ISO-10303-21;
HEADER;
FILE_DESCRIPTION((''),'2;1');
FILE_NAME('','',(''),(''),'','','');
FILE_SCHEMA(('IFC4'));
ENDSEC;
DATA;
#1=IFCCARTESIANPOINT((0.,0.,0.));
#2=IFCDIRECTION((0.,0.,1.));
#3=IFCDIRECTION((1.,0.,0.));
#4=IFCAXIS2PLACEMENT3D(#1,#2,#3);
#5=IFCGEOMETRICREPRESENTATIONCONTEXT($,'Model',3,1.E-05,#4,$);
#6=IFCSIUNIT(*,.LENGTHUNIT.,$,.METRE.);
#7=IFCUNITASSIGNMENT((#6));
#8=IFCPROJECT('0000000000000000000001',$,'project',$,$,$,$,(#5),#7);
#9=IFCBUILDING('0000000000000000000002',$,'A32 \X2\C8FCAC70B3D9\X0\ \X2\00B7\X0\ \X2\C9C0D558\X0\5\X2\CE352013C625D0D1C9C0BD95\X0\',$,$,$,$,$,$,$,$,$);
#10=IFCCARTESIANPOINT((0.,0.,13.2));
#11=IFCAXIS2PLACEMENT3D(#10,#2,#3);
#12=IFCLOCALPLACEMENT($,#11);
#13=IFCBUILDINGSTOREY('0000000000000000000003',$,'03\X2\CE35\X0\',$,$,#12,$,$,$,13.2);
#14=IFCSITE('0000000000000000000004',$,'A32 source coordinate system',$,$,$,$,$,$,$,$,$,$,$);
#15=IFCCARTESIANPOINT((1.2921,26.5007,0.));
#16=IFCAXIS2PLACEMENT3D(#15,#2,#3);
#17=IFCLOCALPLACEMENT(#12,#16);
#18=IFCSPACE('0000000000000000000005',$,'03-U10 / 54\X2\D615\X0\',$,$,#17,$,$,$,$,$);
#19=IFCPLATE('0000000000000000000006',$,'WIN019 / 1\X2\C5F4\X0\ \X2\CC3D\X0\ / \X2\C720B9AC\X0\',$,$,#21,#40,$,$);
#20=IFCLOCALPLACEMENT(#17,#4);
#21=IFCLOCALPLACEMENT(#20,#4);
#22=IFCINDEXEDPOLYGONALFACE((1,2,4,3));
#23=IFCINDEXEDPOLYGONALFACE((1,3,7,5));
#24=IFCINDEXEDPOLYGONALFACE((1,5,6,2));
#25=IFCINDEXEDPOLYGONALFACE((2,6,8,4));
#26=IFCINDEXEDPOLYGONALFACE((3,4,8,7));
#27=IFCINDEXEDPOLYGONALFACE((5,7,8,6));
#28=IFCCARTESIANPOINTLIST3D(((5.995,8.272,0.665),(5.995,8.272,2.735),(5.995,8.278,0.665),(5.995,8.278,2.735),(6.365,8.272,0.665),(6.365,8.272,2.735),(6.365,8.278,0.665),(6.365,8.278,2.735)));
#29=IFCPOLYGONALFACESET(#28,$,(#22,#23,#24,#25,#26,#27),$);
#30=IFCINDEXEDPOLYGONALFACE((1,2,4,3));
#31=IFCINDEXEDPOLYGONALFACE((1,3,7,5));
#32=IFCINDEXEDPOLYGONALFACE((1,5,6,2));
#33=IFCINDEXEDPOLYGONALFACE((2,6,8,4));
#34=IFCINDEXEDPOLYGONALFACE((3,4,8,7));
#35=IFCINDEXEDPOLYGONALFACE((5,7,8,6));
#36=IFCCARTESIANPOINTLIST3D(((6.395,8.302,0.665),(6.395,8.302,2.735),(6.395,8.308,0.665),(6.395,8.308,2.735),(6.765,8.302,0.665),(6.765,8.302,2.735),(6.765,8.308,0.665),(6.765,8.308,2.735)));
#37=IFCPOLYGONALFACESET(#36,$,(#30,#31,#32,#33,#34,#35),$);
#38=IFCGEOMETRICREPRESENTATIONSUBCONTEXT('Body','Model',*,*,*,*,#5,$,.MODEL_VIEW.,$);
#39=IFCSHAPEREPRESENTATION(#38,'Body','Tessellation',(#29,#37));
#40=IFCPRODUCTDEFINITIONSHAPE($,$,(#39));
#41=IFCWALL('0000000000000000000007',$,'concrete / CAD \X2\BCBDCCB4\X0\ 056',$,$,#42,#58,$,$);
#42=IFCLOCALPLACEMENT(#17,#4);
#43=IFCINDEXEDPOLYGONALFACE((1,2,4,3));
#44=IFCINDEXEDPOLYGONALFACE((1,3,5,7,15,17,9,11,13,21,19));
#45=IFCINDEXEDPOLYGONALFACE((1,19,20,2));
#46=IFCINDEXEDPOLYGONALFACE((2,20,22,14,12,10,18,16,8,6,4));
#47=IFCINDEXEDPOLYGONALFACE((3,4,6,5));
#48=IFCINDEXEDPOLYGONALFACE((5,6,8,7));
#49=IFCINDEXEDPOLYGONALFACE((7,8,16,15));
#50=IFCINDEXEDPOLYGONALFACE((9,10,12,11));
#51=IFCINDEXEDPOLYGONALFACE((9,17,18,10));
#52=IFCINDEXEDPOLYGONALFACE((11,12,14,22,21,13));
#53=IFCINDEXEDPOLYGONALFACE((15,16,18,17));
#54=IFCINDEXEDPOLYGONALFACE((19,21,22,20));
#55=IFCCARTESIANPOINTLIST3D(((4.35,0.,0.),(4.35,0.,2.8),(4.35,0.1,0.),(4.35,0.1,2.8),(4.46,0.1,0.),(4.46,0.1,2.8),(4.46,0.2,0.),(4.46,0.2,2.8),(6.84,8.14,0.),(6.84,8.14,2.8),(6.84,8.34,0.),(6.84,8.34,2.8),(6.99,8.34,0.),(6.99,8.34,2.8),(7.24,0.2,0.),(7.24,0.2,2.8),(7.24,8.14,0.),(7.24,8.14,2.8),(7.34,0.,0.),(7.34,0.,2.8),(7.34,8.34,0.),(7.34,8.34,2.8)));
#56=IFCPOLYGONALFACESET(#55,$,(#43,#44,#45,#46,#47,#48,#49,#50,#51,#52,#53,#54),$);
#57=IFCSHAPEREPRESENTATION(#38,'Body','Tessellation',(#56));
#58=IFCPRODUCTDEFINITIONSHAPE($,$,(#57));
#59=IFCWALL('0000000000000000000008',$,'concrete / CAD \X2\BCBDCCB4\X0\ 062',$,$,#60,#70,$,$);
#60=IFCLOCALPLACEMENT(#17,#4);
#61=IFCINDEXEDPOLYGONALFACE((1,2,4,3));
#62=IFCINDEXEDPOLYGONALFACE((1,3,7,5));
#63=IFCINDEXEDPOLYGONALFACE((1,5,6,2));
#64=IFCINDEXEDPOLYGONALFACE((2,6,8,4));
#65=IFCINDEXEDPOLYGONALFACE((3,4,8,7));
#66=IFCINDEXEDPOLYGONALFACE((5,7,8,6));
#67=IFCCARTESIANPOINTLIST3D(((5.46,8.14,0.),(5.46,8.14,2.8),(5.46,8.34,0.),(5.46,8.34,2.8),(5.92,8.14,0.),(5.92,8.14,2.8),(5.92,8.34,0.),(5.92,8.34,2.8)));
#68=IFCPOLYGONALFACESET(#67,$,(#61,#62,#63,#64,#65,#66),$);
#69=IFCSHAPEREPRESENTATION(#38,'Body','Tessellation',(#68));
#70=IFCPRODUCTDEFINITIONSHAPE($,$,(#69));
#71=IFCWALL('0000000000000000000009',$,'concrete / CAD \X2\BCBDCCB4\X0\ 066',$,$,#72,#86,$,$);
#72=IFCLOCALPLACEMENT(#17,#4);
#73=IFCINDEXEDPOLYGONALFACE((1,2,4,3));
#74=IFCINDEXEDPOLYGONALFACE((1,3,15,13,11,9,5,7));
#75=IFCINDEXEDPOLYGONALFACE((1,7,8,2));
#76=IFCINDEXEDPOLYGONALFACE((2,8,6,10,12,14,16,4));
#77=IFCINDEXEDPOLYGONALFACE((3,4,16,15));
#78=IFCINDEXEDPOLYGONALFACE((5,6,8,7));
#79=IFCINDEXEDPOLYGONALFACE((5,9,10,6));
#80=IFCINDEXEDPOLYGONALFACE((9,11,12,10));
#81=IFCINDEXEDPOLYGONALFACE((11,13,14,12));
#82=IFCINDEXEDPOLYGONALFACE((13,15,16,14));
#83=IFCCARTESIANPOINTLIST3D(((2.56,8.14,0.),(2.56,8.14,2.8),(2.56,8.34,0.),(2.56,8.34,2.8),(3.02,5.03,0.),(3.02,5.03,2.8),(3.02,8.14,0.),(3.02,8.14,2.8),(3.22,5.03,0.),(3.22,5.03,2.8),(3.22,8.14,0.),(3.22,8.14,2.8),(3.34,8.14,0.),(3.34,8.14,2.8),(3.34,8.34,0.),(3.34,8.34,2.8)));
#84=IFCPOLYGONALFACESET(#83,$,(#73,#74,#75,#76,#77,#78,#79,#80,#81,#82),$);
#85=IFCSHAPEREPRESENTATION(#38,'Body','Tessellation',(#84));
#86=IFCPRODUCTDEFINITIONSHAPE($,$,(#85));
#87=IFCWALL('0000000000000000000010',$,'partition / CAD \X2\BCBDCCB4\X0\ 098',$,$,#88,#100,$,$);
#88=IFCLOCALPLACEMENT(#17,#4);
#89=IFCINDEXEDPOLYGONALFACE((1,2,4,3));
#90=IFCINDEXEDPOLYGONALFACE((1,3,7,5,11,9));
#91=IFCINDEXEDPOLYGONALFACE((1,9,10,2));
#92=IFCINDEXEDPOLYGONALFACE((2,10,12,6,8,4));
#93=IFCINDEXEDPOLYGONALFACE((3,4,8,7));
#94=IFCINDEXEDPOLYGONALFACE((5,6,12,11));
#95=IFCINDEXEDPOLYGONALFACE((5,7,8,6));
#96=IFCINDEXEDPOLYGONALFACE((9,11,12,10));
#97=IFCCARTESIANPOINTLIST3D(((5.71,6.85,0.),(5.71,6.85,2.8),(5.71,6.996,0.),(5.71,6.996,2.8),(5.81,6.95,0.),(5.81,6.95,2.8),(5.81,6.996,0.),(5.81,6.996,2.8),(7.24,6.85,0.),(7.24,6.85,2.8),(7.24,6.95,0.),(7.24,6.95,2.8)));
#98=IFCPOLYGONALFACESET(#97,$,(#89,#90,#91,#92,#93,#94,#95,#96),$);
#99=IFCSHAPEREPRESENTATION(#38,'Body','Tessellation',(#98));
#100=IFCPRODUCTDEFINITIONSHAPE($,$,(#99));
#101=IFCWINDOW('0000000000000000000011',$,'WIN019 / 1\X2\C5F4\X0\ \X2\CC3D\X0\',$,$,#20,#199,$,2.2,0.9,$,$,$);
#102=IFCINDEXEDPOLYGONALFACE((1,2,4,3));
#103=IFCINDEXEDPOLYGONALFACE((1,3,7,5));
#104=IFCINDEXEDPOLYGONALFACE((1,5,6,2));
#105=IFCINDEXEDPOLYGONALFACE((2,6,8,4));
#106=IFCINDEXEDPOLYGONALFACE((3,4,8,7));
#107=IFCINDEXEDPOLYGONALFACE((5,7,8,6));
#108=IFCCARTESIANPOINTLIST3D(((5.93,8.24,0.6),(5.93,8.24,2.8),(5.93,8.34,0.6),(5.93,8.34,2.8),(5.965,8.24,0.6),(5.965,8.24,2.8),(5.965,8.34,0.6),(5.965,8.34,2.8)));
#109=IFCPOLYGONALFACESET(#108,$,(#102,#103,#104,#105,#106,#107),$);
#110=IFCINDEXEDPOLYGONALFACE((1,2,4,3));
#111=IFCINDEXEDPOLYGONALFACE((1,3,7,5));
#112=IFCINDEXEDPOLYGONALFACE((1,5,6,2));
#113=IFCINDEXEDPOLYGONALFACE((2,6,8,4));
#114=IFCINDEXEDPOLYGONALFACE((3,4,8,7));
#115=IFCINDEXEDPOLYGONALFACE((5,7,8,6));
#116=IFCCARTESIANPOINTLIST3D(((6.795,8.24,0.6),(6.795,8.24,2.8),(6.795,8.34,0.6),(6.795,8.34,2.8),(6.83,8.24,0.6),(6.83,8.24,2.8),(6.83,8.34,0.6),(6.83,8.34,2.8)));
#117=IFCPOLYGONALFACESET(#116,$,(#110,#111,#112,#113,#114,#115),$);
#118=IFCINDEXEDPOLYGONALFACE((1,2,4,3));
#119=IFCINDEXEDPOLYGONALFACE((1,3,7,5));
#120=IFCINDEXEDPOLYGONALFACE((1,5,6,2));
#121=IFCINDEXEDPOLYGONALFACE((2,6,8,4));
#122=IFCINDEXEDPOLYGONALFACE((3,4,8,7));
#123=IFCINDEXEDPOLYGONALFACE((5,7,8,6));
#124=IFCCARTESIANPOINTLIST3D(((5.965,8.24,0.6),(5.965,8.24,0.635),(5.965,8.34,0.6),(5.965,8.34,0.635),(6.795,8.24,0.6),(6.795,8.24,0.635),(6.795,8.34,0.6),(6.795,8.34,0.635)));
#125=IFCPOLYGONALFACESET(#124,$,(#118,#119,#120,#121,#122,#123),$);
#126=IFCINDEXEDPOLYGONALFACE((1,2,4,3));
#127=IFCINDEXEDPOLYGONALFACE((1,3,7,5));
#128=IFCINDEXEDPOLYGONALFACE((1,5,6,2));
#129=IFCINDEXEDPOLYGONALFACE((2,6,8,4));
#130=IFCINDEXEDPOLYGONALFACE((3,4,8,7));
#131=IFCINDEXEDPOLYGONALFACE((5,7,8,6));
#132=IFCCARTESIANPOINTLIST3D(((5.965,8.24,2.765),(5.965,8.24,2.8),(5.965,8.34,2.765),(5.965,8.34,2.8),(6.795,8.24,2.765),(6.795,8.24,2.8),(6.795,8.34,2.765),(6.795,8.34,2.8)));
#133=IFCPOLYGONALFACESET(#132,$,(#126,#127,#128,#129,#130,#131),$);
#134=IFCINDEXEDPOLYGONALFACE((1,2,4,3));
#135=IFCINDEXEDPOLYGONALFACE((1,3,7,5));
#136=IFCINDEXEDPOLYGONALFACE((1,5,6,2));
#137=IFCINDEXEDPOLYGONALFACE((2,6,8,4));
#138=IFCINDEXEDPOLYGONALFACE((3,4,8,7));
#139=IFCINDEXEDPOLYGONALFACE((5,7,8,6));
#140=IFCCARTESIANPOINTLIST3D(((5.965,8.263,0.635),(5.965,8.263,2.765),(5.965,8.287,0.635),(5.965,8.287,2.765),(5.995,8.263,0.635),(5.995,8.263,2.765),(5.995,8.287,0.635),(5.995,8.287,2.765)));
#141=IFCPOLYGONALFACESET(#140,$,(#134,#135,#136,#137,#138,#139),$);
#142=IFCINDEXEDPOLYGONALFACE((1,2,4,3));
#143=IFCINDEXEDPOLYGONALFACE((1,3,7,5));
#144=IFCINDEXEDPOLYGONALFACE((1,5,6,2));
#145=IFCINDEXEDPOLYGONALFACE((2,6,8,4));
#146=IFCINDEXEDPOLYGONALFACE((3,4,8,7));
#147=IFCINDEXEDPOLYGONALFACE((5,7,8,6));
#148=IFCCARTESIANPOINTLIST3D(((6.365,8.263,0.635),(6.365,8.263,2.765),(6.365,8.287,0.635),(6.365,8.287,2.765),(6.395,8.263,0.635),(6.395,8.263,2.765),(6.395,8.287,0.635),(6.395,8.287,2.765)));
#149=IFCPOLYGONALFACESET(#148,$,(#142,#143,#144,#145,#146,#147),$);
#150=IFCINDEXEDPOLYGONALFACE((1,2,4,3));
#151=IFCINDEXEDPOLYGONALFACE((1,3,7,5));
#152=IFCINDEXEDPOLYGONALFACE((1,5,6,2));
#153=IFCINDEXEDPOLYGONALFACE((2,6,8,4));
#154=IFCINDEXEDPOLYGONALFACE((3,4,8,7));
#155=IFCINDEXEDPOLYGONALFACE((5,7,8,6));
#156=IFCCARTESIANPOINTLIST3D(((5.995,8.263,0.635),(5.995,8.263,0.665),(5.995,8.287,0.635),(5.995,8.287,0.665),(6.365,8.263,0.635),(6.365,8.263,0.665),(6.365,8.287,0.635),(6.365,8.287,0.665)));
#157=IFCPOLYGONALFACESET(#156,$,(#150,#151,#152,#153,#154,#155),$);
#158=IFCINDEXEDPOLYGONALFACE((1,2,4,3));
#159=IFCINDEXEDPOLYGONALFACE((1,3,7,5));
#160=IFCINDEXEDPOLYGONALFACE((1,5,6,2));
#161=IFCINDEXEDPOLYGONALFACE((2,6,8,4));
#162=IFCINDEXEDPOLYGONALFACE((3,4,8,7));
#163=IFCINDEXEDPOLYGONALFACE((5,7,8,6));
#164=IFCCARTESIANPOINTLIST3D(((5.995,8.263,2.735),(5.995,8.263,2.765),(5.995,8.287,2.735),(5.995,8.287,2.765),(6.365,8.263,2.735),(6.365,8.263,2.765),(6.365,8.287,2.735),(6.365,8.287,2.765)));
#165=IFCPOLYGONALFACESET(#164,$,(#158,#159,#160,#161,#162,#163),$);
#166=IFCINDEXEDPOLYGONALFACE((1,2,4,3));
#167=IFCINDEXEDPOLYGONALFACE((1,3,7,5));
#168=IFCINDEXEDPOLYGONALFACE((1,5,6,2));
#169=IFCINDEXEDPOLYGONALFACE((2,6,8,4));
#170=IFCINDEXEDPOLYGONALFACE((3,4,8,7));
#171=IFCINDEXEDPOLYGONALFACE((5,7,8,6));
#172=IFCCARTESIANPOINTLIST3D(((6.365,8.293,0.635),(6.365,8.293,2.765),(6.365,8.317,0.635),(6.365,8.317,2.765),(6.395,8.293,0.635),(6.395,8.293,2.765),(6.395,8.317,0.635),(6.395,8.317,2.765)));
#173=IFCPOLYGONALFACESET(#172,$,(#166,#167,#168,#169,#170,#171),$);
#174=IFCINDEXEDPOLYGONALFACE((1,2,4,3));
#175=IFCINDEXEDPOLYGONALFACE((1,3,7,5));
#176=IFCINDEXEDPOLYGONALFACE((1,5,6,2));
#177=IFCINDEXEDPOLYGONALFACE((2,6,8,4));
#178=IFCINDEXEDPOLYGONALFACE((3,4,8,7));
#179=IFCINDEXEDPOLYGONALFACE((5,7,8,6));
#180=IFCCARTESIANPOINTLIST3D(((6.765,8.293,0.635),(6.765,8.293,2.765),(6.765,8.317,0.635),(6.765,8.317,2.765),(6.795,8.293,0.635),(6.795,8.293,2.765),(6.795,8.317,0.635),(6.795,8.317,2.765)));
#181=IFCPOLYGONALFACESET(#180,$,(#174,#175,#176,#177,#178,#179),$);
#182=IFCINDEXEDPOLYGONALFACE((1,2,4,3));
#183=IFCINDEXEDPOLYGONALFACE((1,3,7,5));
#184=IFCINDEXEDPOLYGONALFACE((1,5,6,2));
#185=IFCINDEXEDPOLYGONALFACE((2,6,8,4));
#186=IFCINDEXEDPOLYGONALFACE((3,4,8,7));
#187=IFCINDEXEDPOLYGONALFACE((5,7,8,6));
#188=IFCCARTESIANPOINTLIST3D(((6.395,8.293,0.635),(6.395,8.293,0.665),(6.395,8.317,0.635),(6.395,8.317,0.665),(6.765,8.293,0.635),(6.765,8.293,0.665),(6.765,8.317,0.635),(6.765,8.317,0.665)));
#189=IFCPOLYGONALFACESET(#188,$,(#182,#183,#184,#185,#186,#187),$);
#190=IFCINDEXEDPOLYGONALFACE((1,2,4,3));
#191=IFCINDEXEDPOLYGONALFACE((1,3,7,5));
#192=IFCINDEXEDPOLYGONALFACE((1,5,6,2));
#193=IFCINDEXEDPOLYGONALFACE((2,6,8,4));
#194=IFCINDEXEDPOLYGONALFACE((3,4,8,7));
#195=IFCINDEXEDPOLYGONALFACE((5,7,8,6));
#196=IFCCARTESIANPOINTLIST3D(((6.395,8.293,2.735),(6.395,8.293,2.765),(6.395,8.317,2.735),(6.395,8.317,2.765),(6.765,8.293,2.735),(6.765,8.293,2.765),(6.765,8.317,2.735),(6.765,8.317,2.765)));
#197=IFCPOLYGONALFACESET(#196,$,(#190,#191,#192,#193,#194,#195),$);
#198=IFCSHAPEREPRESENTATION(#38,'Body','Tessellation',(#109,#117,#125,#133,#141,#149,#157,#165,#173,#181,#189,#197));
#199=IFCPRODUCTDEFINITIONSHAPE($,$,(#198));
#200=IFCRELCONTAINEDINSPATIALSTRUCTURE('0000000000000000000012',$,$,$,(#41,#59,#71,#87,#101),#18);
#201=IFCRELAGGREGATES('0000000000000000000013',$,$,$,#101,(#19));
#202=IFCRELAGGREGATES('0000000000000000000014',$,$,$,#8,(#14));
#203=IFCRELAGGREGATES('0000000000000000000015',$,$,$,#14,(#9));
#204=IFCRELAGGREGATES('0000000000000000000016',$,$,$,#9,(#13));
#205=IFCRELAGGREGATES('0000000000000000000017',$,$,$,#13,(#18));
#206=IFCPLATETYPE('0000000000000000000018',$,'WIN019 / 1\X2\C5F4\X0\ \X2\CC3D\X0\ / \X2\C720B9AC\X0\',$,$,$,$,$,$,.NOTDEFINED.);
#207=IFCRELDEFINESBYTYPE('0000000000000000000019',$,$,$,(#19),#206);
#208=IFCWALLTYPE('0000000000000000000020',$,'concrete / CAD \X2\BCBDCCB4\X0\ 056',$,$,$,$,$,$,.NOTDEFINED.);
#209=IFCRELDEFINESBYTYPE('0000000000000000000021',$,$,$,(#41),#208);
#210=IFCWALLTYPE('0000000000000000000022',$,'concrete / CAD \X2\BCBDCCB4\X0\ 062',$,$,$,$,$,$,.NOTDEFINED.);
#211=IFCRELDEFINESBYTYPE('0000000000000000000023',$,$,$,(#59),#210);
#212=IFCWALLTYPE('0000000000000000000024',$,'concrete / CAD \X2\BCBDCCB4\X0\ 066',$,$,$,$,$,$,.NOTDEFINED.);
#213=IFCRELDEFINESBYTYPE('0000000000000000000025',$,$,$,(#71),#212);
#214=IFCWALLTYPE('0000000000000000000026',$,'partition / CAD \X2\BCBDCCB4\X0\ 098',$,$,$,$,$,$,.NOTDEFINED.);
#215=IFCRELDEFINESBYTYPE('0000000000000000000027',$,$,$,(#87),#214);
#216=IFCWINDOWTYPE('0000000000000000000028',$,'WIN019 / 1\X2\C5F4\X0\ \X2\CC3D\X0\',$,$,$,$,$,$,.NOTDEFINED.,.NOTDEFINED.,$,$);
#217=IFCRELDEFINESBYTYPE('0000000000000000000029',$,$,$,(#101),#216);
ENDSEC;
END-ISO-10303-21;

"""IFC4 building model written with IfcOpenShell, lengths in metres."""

from ifc_helpers import new_model, si_unit, frame, origin, origin_with_axes, place, context, subcontext, project, spatial, polyline, outline, extrude, source, transform, mapped, type_object, type_shapes, element, aggregate, save


model = new_model("IFC4")

# Units and contexts
model_context = context("Model", 3, precision=1e-05, world=origin_with_axes())
body_context = subcontext(model_context, "Body", "Model", "MODEL_VIEW")
ifc_project = project(units=[si_unit("LENGTHUNIT", "METRE")], contexts=[model_context])

# Plate
plate_type = type_object("IfcPlateType", Name="WIN019 / 1열 창 / 유리", PredefinedType="NOTDEFINED")
shared_shape_1 = source(origin(), body_context, "Body", "SweptSolid", [
    extrude(outline(polyline([(5.995, 8.272), (5.995, 8.278), (6.365, 8.278), (6.365, 8.272), (5.995, 8.272)])), frame((0.0, 0.0, 0.665)), (0.0, 0.0, 1.0), 2.07),
    extrude(outline(polyline([(6.395, 8.302), (6.395, 8.308), (6.765, 8.308), (6.765, 8.302), (6.395, 8.302)])), frame((0.0, 0.0, 0.665)), (0.0, 0.0, 1.0), 2.07),
])
type_shapes(plate_type, [shared_shape_1])
storey_placement = place(None, frame((0.0, 0.0, 13.2), z_axis=(0.0, 0.0, 1.0), x_axis=(1.0, 0.0, 0.0)))
space_placement = place(storey_placement, frame((1.2921, 26.5007, 0.0), z_axis=(0.0, 0.0, 1.0), x_axis=(1.0, 0.0, 0.0)))
window_placement = place(space_placement, origin_with_axes())
plate_placement = place(window_placement, origin_with_axes())
plate = element("IfcPlate", 1, at=plate_placement, type_object=plate_type, Name="WIN019 / 1열 창 / 유리", context=body_context, shape_type="MappedRepresentation", body=[
    mapped(shared_shape_1, transform((0.0, 0.0, 0.0), scale=1.0)),
])

# Site, building, storey, space
site = spatial("IfcSite", under=ifc_project, Name="A32 source coordinate system")
building = spatial("IfcBuilding", under=site, Name="A32 주거동 · 지하5층–옥탑지붕")
storey = spatial("IfcBuildingStorey", under=building, at=storey_placement, Name="03층", Elevation=13.2)
space = spatial("IfcSpace", under=storey, at=space_placement, Name="03-U10 / 54형")

# Walls
wall_type_1 = type_object("IfcWallType", Name="concrete / CAD 벽체 056", PredefinedType="NOTDEFINED")
shared_shape_2 = source(origin(), body_context, "Body", "SweptSolid", [
    extrude(outline(polyline([(7.24, 0.2), (7.24, 8.14), (6.84, 8.14), (6.84, 8.34), (6.99, 8.34), (6.99, 8.34), (7.34, 8.34), (7.34, 0.0), (4.35, 0.0), (4.35, 0.1), (4.46, 0.1), (4.46, 0.2), (7.24, 0.2)])), origin(), (0.0, 0.0, 1.0), 2.8),
])
type_shapes(wall_type_1, [shared_shape_2])
wall_1_placement = place(space_placement, origin_with_axes())
element("IfcWall", 2, at=wall_1_placement, inside=space, type_object=wall_type_1, Name="concrete / CAD 벽체 056", context=body_context, shape_type="MappedRepresentation", body=[
    mapped(shared_shape_2, transform((0.0, 0.0, 0.0), scale=1.0)),
])
wall_type_2 = type_object("IfcWallType", Name="concrete / CAD 벽체 062", PredefinedType="NOTDEFINED")
shared_shape_3 = source(origin(), body_context, "Body", "SweptSolid", [
    extrude(outline(polyline([(5.46, 8.14), (5.46, 8.34), (5.92, 8.34), (5.92, 8.14), (5.46, 8.14)])), origin(), (0.0, 0.0, 1.0), 2.8),
])
type_shapes(wall_type_2, [shared_shape_3])
wall_2_placement = place(space_placement, origin_with_axes())
element("IfcWall", 3, at=wall_2_placement, inside=space, type_object=wall_type_2, Name="concrete / CAD 벽체 062", context=body_context, shape_type="MappedRepresentation", body=[
    mapped(shared_shape_3, transform((0.0, 0.0, 0.0), scale=1.0)),
])
wall_type_3 = type_object("IfcWallType", Name="concrete / CAD 벽체 066", PredefinedType="NOTDEFINED")
shared_shape_4 = source(origin(), body_context, "Body", "SweptSolid", [
    extrude(outline(polyline([(3.22, 8.14), (3.22, 5.03), (3.02, 5.03), (3.02, 8.14), (2.56, 8.14), (2.56, 8.34), (3.34, 8.34), (3.34, 8.14), (3.22, 8.14)])), origin(), (0.0, 0.0, 1.0), 2.8),
])
type_shapes(wall_type_3, [shared_shape_4])
wall_3_placement = place(space_placement, origin_with_axes())
element("IfcWall", 4, at=wall_3_placement, inside=space, type_object=wall_type_3, Name="concrete / CAD 벽체 066", context=body_context, shape_type="MappedRepresentation", body=[
    mapped(shared_shape_4, transform((0.0, 0.0, 0.0), scale=1.0)),
])
wall_type_4 = type_object("IfcWallType", Name="partition / CAD 벽체 098", PredefinedType="NOTDEFINED")
shared_shape_5 = source(origin(), body_context, "Body", "SweptSolid", [
    extrude(outline(polyline([(5.71, 6.996), (5.81, 6.996), (5.81, 6.95), (7.24, 6.95), (7.24, 6.85), (5.71, 6.85), (5.71, 6.996)])), origin(), (0.0, 0.0, 1.0), 2.8),
])
type_shapes(wall_type_4, [shared_shape_5])
wall_4_placement = place(space_placement, origin_with_axes())
element("IfcWall", 5, at=wall_4_placement, inside=space, type_object=wall_type_4, Name="partition / CAD 벽체 098", context=body_context, shape_type="MappedRepresentation", body=[
    mapped(shared_shape_5, transform((0.0, 0.0, 0.0), scale=1.0)),
])

# Window
window_type = type_object("IfcWindowType", Name="WIN019 / 1열 창", PartitioningType="NOTDEFINED", PredefinedType="NOTDEFINED")
shared_shape_6 = source(origin(), body_context, "Body", "SweptSolid", [
    extrude(outline(polyline([(5.93, 8.24), (5.93, 8.34), (5.965, 8.34), (5.965, 8.24), (5.93, 8.24)])), frame((0.0, 0.0, 0.6)), (0.0, 0.0, 1.0), 2.2),
    extrude(outline(polyline([(6.795, 8.24), (6.795, 8.34), (6.83, 8.34), (6.83, 8.24), (6.795, 8.24)])), frame((0.0, 0.0, 0.6)), (0.0, 0.0, 1.0), 2.2),
    extrude(outline(polyline([(5.965, 8.24), (5.965, 8.34), (6.795, 8.34), (6.795, 8.24), (5.965, 8.24)])), frame((0.0, 0.0, 0.6)), (0.0, 0.0, 1.0), 0.035),
    extrude(outline(polyline([(5.965, 8.24), (5.965, 8.34), (6.795, 8.34), (6.795, 8.24), (5.965, 8.24)])), frame((0.0, 0.0, 2.765)), (0.0, 0.0, 1.0), 0.035),
    extrude(outline(polyline([(5.965, 8.263), (5.965, 8.287), (5.995, 8.287), (5.995, 8.263), (5.965, 8.263)])), frame((0.0, 0.0, 0.635)), (0.0, 0.0, 1.0), 2.13),
    extrude(outline(polyline([(6.365, 8.263), (6.365, 8.287), (6.395, 8.287), (6.395, 8.263), (6.365, 8.263)])), frame((0.0, 0.0, 0.635)), (0.0, 0.0, 1.0), 2.13),
    extrude(outline(polyline([(5.995, 8.263), (5.995, 8.287), (6.365, 8.287), (6.365, 8.263), (5.995, 8.263)])), frame((0.0, 0.0, 0.635)), (0.0, 0.0, 1.0), 0.03),
    extrude(outline(polyline([(5.995, 8.263), (5.995, 8.287), (6.365, 8.287), (6.365, 8.263), (5.995, 8.263)])), frame((0.0, 0.0, 2.735)), (0.0, 0.0, 1.0), 0.03),
    extrude(outline(polyline([(6.365, 8.293), (6.365, 8.317), (6.395, 8.317), (6.395, 8.293), (6.365, 8.293)])), frame((0.0, 0.0, 0.635)), (0.0, 0.0, 1.0), 2.13),
    extrude(outline(polyline([(6.765, 8.293), (6.765, 8.317), (6.795, 8.317), (6.795, 8.293), (6.765, 8.293)])), frame((0.0, 0.0, 0.635)), (0.0, 0.0, 1.0), 2.13),
    extrude(outline(polyline([(6.395, 8.293), (6.395, 8.317), (6.765, 8.317), (6.765, 8.293), (6.395, 8.293)])), frame((0.0, 0.0, 0.635)), (0.0, 0.0, 1.0), 0.03),
    extrude(outline(polyline([(6.395, 8.293), (6.395, 8.317), (6.765, 8.317), (6.765, 8.293), (6.395, 8.293)])), frame((0.0, 0.0, 2.735)), (0.0, 0.0, 1.0), 0.03),
])
type_shapes(window_type, [shared_shape_6])
window = element("IfcWindow", 6, at=window_placement, inside=space, type_object=window_type, Name="WIN019 / 1열 창", OverallHeight=2.2, OverallWidth=0.9, context=body_context, shape_type="MappedRepresentation", body=[
    mapped(shared_shape_6, transform((0.0, 0.0, 0.0), scale=1.0)),
])
aggregate(window, [plate])

save(model, "model.ifc")
